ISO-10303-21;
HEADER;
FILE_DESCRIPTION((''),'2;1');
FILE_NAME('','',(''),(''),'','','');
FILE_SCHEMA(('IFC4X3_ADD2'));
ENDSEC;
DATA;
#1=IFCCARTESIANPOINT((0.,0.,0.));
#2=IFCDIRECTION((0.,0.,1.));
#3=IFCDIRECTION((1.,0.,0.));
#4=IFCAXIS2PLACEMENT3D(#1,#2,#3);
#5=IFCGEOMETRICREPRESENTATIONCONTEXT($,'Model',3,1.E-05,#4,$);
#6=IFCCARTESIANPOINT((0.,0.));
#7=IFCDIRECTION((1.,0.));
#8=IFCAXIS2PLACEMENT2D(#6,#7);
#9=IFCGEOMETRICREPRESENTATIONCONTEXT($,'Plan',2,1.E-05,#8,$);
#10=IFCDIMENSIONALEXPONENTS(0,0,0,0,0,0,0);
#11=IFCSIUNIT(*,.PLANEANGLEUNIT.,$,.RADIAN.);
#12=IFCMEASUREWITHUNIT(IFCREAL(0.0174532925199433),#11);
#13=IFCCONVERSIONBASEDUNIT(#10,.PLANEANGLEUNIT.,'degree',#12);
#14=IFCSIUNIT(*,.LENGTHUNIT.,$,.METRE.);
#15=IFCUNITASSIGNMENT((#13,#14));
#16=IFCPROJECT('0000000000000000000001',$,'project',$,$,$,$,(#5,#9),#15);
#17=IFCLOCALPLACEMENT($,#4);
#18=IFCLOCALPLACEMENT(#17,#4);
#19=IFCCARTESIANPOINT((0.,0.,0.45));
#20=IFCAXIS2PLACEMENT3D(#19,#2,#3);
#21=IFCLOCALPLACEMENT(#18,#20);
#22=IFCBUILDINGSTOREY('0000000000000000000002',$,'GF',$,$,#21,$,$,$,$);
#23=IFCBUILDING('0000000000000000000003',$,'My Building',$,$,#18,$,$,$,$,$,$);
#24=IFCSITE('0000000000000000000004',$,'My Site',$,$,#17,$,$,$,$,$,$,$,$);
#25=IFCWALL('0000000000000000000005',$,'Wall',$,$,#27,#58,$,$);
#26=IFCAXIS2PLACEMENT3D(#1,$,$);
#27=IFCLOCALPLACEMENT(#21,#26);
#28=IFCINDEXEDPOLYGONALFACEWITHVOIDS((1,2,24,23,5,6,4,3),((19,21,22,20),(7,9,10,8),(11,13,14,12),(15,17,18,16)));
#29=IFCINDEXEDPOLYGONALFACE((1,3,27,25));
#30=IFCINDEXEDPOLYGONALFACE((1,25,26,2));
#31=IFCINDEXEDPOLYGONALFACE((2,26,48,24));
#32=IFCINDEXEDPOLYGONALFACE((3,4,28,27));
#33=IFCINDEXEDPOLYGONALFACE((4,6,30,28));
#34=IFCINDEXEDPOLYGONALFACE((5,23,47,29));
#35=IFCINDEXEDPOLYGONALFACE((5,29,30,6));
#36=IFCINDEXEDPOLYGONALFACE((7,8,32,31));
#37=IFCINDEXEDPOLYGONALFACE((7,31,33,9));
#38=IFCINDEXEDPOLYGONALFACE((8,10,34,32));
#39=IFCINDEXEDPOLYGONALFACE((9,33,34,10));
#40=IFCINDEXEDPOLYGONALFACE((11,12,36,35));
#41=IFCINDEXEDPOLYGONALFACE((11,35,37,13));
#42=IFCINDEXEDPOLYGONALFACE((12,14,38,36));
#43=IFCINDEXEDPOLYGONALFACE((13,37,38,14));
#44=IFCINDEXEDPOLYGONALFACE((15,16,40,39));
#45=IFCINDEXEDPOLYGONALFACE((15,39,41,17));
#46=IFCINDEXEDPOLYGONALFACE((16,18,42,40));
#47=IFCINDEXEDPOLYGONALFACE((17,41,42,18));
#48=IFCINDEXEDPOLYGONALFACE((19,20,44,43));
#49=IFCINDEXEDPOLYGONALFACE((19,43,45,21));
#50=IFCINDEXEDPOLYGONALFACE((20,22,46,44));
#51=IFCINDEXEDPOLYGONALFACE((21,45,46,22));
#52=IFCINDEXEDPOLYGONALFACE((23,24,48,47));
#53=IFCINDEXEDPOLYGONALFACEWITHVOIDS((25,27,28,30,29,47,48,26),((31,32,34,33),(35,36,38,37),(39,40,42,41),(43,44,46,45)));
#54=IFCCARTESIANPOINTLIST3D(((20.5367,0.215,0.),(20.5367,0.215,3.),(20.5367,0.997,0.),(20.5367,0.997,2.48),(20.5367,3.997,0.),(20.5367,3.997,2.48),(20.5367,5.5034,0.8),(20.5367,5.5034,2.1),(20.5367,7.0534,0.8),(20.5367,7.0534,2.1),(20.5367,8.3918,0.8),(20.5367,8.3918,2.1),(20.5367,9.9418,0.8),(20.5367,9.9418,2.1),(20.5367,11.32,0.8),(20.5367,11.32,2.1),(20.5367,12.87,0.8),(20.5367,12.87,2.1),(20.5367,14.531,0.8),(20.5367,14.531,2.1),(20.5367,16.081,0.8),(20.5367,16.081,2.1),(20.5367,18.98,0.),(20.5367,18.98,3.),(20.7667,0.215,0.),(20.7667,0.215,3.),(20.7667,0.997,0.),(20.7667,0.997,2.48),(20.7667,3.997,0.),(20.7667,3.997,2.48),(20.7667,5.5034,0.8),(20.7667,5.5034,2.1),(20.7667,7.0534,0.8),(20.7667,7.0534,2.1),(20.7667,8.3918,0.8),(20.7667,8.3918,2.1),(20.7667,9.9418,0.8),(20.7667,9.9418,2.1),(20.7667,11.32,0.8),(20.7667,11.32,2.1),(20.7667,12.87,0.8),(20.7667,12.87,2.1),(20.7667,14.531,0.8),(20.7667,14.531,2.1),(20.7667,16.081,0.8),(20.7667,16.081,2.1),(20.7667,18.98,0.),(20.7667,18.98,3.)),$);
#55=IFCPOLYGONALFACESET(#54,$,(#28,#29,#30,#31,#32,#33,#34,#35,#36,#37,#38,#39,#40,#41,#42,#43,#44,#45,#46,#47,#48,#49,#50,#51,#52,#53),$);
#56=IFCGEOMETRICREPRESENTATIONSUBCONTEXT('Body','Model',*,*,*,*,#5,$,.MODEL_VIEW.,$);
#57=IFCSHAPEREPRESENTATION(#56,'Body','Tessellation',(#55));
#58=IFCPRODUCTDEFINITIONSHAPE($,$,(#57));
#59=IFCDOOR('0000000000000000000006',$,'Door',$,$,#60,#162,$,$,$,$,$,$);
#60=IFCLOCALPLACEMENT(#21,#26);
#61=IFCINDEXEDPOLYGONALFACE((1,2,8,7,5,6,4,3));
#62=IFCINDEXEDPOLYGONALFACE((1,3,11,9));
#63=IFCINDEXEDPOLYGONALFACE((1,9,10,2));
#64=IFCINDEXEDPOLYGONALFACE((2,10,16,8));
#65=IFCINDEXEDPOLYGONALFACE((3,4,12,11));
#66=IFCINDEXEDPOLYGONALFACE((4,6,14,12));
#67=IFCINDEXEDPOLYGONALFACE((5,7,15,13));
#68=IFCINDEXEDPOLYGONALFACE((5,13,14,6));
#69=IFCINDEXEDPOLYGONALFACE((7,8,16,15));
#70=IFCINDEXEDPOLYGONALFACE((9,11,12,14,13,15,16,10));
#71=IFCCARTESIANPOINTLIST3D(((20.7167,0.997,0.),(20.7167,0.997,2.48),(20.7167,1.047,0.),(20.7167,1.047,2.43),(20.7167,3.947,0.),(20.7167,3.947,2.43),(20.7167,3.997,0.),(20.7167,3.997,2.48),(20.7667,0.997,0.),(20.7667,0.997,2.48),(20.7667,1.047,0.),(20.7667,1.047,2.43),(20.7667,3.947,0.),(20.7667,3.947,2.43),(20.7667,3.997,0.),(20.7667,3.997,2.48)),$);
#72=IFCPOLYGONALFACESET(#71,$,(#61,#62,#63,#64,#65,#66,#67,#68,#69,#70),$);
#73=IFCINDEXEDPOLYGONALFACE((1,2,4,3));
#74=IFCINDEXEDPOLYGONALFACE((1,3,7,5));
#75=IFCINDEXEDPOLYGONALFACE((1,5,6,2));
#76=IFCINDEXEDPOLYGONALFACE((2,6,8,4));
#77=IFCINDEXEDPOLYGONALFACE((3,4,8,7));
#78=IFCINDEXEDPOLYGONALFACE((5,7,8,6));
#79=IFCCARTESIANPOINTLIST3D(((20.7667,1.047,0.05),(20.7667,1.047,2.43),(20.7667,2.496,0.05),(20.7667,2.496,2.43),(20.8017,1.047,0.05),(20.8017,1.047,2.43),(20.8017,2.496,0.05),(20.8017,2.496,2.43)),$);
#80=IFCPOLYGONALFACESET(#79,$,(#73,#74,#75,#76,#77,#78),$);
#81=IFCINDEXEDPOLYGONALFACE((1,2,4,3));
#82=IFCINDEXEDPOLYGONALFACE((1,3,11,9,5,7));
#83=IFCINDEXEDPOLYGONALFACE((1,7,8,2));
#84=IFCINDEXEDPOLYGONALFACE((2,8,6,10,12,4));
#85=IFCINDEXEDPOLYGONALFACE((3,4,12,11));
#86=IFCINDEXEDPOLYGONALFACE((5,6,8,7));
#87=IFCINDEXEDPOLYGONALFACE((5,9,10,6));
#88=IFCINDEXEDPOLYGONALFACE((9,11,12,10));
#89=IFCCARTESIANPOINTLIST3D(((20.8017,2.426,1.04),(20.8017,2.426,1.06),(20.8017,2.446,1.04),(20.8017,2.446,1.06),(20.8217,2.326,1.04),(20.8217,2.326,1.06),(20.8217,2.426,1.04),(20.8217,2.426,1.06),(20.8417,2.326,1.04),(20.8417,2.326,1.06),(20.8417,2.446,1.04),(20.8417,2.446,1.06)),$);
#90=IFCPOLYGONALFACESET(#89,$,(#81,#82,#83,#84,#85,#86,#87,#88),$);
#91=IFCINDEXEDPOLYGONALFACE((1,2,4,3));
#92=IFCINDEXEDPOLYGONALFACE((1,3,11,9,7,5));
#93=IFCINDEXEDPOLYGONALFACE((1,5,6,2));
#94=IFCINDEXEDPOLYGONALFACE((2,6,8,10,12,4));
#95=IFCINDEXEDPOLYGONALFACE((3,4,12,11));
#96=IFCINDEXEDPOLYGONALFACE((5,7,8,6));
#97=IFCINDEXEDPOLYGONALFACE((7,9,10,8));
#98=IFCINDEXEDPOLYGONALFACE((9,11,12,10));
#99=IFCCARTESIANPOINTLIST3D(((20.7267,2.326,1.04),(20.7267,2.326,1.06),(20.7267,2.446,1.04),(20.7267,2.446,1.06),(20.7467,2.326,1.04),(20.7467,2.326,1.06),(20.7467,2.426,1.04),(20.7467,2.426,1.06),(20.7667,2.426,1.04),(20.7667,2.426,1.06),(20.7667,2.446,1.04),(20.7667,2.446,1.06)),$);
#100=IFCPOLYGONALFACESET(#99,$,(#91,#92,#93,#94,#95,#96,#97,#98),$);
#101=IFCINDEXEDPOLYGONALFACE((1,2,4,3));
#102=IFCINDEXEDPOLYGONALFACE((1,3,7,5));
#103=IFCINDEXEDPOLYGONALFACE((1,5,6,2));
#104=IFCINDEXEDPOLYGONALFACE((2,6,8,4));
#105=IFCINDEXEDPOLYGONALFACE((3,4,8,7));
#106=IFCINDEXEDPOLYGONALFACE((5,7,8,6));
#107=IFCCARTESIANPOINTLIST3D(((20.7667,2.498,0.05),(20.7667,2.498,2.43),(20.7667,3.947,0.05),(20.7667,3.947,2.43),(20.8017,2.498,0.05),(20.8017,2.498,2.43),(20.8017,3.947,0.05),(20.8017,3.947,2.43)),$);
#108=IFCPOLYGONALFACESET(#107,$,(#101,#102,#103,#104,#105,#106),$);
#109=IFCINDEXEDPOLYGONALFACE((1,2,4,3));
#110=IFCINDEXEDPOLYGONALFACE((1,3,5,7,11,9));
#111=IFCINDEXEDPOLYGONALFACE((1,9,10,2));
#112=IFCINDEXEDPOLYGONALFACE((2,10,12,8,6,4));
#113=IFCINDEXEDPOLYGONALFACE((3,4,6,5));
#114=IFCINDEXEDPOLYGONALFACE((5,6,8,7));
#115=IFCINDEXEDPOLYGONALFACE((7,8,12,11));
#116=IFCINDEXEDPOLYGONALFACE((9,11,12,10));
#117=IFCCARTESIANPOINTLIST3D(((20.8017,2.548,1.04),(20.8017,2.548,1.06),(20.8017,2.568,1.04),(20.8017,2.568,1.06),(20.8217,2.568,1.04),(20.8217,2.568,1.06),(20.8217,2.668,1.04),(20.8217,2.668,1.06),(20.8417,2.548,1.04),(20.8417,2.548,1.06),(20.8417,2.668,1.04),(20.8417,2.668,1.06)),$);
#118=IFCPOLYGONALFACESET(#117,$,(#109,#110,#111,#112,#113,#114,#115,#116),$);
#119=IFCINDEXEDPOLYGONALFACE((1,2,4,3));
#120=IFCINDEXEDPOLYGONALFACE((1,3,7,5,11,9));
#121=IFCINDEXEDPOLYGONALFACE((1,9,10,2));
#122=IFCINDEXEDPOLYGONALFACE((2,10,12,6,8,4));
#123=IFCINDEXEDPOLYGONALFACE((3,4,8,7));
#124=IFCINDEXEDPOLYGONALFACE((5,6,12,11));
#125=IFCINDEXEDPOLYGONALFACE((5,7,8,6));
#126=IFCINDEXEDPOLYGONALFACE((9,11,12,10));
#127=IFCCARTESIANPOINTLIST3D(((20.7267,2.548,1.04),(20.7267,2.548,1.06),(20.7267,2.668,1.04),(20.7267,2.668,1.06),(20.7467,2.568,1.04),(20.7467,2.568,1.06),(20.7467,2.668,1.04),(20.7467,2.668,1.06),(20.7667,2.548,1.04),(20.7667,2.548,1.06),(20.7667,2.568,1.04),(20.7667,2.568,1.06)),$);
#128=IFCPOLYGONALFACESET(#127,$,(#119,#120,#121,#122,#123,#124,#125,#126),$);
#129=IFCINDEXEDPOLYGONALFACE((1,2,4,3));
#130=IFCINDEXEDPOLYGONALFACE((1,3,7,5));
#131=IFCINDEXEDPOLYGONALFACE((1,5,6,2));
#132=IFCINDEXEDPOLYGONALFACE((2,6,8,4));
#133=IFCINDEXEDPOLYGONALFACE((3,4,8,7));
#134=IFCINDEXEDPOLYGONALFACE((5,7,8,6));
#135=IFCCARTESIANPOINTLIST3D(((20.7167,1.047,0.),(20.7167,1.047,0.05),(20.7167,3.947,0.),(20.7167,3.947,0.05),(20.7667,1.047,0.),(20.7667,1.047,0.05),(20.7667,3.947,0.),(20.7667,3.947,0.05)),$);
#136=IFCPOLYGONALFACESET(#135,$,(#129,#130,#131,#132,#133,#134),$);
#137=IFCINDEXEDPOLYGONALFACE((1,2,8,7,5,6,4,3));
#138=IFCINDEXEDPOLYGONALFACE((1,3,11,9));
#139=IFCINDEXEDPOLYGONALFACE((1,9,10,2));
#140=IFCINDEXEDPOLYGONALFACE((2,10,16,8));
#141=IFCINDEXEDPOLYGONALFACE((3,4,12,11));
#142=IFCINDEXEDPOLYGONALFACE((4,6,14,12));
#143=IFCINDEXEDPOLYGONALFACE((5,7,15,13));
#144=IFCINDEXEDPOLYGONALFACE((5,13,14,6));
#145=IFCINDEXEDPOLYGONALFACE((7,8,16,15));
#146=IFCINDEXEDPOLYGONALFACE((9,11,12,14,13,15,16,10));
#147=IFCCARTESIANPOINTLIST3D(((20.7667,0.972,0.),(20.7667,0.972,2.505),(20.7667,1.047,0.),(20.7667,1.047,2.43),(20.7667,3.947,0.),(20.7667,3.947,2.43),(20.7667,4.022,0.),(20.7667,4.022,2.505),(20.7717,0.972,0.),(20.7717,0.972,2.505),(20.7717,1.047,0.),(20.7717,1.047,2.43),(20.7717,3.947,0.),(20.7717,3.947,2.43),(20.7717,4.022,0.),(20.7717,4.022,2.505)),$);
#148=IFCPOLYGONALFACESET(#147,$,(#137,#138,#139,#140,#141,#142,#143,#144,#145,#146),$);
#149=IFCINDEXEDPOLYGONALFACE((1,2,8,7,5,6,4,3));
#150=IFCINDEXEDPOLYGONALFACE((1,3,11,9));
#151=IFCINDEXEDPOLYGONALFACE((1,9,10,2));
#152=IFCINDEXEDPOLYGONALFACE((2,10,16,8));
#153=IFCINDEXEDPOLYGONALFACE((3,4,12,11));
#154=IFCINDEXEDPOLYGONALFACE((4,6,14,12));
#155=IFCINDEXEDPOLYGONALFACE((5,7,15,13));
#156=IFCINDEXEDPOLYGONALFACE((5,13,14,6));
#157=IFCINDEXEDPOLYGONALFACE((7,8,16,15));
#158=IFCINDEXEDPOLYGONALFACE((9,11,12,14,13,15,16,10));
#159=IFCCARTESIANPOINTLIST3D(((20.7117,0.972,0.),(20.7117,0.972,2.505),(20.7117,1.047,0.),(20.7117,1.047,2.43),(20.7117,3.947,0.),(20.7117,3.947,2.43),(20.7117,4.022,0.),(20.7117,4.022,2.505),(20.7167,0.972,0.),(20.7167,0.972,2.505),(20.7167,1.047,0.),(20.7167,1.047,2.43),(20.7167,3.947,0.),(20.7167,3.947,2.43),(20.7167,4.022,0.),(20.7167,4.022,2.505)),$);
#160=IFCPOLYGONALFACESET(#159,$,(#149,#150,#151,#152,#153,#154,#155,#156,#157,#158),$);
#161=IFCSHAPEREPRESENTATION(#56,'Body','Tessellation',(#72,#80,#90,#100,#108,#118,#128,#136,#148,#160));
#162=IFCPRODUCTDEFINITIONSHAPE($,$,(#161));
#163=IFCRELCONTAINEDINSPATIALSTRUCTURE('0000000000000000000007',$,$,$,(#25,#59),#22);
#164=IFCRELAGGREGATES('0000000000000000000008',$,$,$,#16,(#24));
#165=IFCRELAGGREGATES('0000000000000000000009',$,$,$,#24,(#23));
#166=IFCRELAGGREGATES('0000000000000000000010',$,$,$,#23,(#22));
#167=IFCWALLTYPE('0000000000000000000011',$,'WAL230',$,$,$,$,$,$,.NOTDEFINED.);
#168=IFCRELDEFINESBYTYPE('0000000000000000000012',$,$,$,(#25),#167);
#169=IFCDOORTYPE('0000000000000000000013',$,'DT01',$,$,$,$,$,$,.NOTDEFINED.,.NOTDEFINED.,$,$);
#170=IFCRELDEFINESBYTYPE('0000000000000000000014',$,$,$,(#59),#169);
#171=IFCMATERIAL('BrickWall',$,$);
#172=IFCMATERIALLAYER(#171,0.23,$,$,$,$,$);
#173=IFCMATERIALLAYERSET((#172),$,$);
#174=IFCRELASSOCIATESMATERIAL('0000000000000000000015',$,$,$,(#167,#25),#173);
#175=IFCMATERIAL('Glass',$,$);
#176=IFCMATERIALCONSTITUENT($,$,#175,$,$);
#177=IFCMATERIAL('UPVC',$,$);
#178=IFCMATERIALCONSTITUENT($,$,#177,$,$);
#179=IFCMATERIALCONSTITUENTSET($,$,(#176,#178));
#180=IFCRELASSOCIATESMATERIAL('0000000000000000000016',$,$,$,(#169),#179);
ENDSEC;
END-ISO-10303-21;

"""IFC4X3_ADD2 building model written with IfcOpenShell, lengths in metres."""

from ifc_helpers import new_model, entity, si_unit, converted_unit, frame, origin_with_axes, origin_2d_with_axis, place, context, subcontext, project, spatial, line, indexed_curve, outline, extrude, shape, source, transform, mapped, material, layer, layer_set, layer_usage, constituent, constituent_set, type_object, type_shapes, element, fill, save


model = new_model("IFC4X3_ADD2")

# Units and contexts
model_context = context("Model", 3, precision=1e-05, world=origin_with_axes())
plan_context = context("Plan", 2, precision=1e-05, world=origin_2d_with_axis())
body_context_1 = subcontext(model_context, "Body", "Model", "MODEL_VIEW")
body_context_2 = subcontext(plan_context, "Body", "Plan", "PLAN_VIEW")
ifc_project = project(units=[converted_unit("PLANEANGLEUNIT", "degree", entity("IfcReal", 0.0174532925199433), si_unit("PLANEANGLEUNIT", "RADIAN"), dimensions=[0, 0, 0, 0, 0, 0, 0]), si_unit("LENGTHUNIT", "METRE")], contexts=[model_context, plan_context])

# Site, building, storey
site_placement = place(None, origin_with_axes())
site = spatial("IfcSite", under=ifc_project, at=site_placement, Name="My Site")
building_placement = place(site_placement, origin_with_axes())
building = spatial("IfcBuilding", under=site, at=building_placement, Name="My Building")
storey_placement = place(building_placement, frame((0.0, 0.0, 0.45), z_axis=(0.0, 0.0, 1.0), x_axis=(1.0, 0.0, 0.0)))
storey = spatial("IfcBuildingStorey", under=building, at=storey_placement, Name="GF")

# Shared definitions
ifc_material_1 = material(Name="BrickWall")
ifc_layer_1 = layer(ifc_material_1, 0.23)
ifc_layer_set_1 = layer_set([ifc_layer_1])
wall_type_1 = type_object("IfcWallType", Name="WAL230", PredefinedType="NOTDEFINED", material=ifc_layer_set_1)
shared_shape_1 = source(origin_with_axes(), body_context_1, "Body", "SweptSolid", [
    extrude(outline(indexed_curve([(0.0, 0.0), (3.0, 0.0), (3.0, 2.48), (0.0, 2.48)], segments=[line(1, 2, 3, 4, 1)])), frame((0.0, -0.6, 0.0), z_axis=(0.0, -1.0, 0.0), x_axis=(1.0, 0.0, 0.0)), (0.0, 0.0, -1.0), 1.2),
])
ifc_material_2 = material(Name="Glass")
ifc_constituent_1 = constituent(ifc_material_2)
ifc_material_3 = material(Name="UPVC")
ifc_constituent_2 = constituent(ifc_material_3)
ifc_constituent_set = constituent_set(constituents=[ifc_constituent_1, ifc_constituent_2])
door_type_1 = type_object("IfcDoorType", Name="DT01", OperationType="NOTDEFINED", PredefinedType="NOTDEFINED", material=ifc_constituent_set)
shared_shape_2 = source(origin_with_axes(), body_context_1, "Body", "SweptSolid", [
    extrude(outline(indexed_curve([(3.0, 0.0), (3.0, 2.48), (0.0, 2.48), (0.0, 0.0), (0.05, 0.0), (0.05, 2.43), (2.95, 2.43), (2.95, 0.0)], segments=[line(5, 4), line(4, 3), line(3, 2), line(2, 1), line(1, 8), line(8, 7), line(7, 6), line(6, 5)], self_intersect=False)), frame((0.0, 0.0, 0.0), z_axis=(0.0, -1.0, 0.0), x_axis=(1.0, 0.0, 0.0)), (0.0, 0.0, -1.0), 0.05),
    extrude(outline(indexed_curve([(0.0, 0.0), (1.449, 0.0), (1.449, 0.035), (0.0, 0.035)], segments=[line(1, 2, 3, 4, 1)])), frame((0.05, -0.035, 0.05), z_axis=(0.0, 0.0, 1.0), x_axis=(1.0, 0.0, 0.0)), (0.0, 0.0, 1.0), 2.38),
    extrude(outline(indexed_curve([(0.0, 0.0), (0.0, -0.04), (-0.12, -0.04), (-0.12, -0.02), (-0.02, -0.02), (-0.02, 0.0)], segments=[line(1, 2, 3, 4, 5, 6, 1)])), frame((1.449, -0.035, 1.04), z_axis=(0.0, 0.0, 1.0), x_axis=(1.0, 0.0, 0.0)), (0.0, 0.0, 1.0), 0.02),
    extrude(outline(indexed_curve([(0.0, 0.0), (0.0, 0.04), (-0.12, 0.04), (-0.12, 0.02), (-0.02, 0.02), (-0.02, 0.0)], segments=[line(1, 2, 3, 4, 5, 6, 1)])), frame((1.449, 0.0, 1.04), z_axis=(0.0, 0.0, 1.0), x_axis=(1.0, 0.0, 0.0)), (0.0, 0.0, 1.0), 0.02),
    extrude(outline(indexed_curve([(0.0, 0.0), (-1.449, 0.0), (-1.449, 0.035), (0.0, 0.035)], segments=[line(1, 2, 3, 4, 1)])), frame((2.95, -0.035, 0.05), z_axis=(0.0, 0.0, 1.0), x_axis=(1.0, 0.0, 0.0)), (0.0, 0.0, 1.0), 2.38),
    extrude(outline(indexed_curve([(0.0, 0.0), (0.0, -0.04), (0.12, -0.04), (0.12, -0.02), (0.02, -0.02), (0.02, 0.0)], segments=[line(1, 2, 3, 4, 5, 6, 1)])), frame((1.551, -0.035, 1.04), z_axis=(0.0, 0.0, 1.0), x_axis=(1.0, 0.0, 0.0)), (0.0, 0.0, 1.0), 0.02),
    extrude(outline(indexed_curve([(0.0, 0.0), (0.0, 0.04), (0.12, 0.04), (0.12, 0.02), (0.02, 0.02), (0.02, 0.0)], segments=[line(1, 2, 3, 4, 5, 6, 1)])), frame((1.551, 0.0, 1.04), z_axis=(0.0, 0.0, 1.0), x_axis=(1.0, 0.0, 0.0)), (0.0, 0.0, 1.0), 0.02),
    extrude(outline(indexed_curve([(0.0, 0.0), (2.9, 0.0), (2.9, 0.05), (0.0, 0.05)], segments=[line(1, 2, 3, 4, 1)])), frame((0.05, 0.0, 0.0), z_axis=(0.0, 0.0, 1.0), x_axis=(1.0, 0.0, 0.0)), (0.0, 0.0, 1.0), 0.05),
    extrude(outline(indexed_curve([(0.0, 0.0), (0.0, 2.505), (3.05, 2.505), (3.05, 0.0), (2.975, 0.0), (2.975, 2.43), (0.075, 2.43), (0.075, 0.0)], segments=[line(1, 2, 3, 4, 5, 6, 7, 8, 1)])), frame((-0.025, -0.005, 0.0), z_axis=(0.0, -1.0, 0.0), x_axis=(1.0, 0.0, 0.0)), (0.0, 0.0, -1.0), 0.005),
    extrude(outline(indexed_curve([(0.0, 0.0), (0.0, 2.505), (3.05, 2.505), (3.05, 0.0), (2.975, 0.0), (2.975, 2.43), (0.075, 2.43), (0.075, 0.0)], segments=[line(1, 2, 3, 4, 5, 6, 7, 8, 1)])), frame((-0.025, 0.05, 0.0), z_axis=(0.0, -1.0, 0.0), x_axis=(1.0, 0.0, 0.0)), (0.0, 0.0, -1.0), 0.005),
])
shared_shape_3 = source(origin_with_axes(), body_context_2, "Body", "Curve2D", [
    entity("IfcIndexedPolyCurve", entity("IfcCartesianPointList2D", [[0.0, 0.0], [0.05, 0.0], [0.05, 0.05], [0.0, 0.05]]), [entity("IfcLineIndex", [1, 2, 3, 4, 1])]),
    entity("IfcIndexedPolyCurve", entity("IfcCartesianPointList2D", [[3.0, 0.0], [2.95, 0.0], [2.95, 0.05], [3.0, 0.05]]), [entity("IfcLineIndex", [1, 2, 3, 4, 1])]),
    entity("IfcIndexedPolyCurve", entity("IfcCartesianPointList2D", [[-0.675, -0.035], [0.775, -0.035], [0.775, 0.0], [-0.675, 0.0]]), [entity("IfcLineIndex", [1, 2, 3, 4, 1])]),
    entity("IfcIndexedPolyCurve", entity("IfcCartesianPointList2D", [[3.675, -0.035], [2.225, -0.035], [2.225, 0.0], [3.675, 0.0]]), [entity("IfcLineIndex", [1, 2, 3, 4, 1])]),
])
type_shapes(door_type_1, [shared_shape_2, shared_shape_3])

# Wall, openings, door
ifc_layer_usage_1 = layer_usage(ifc_layer_set_1, "AXIS2", "POSITIVE", 0.0)
wall_1_placement = place(storey_placement, frame((20.7667, 0.215, 0.0), z_axis=(0.0, 0.0, 1.0), x_axis=(0.0, 1.0, 0.0)))
wall_1 = element("IfcWall", 1, at=wall_1_placement, inside=storey, type_object=wall_type_1, material=ifc_layer_usage_1, Name="Wall", context=body_context_1, shape_type="SweptSolid", body=[
    extrude(outline(indexed_curve([(0.0, 0.0), (0.0, 0.23), (18.765, 0.23), (18.765, 0.0), (0.0, 0.0)], self_intersect=False)), origin_with_axes(), (0.0, 0.0, 1.0), 3.0),
])
opening_1_placement = place(wall_1_placement, frame((0.782, 0.03, 0.0), z_axis=(0.0, 0.0, 1.0), x_axis=(1.0, 0.0, 0.0)))
opening_1 = element("IfcOpeningElement", 2, at=opening_1_placement, cuts=wall_1, PredefinedType="OPENING", context=body_context_1, shape_type="MappedRepresentation", body=[
    mapped(shared_shape_1, transform((0.0, 0.0, 0.0), x_axis=(1.0, 0.0, 0.0), y_axis=(0.0, 1.0, 0.0), z_axis=(0.0, 0.0, 1.0), scale=1.0)),
])
shared_shape_4 = source(origin_with_axes(), body_context_1, "Body", "SweptSolid", [
    extrude(outline(indexed_curve([(0.0, 0.0), (1.55, 0.0), (1.55, 1.3), (0.0, 1.3)], segments=[line(1, 2, 3, 4, 1)])), frame((-0.775, -0.6, 0.0), z_axis=(0.0, -1.0, 0.0), x_axis=(1.0, 0.0, 0.0)), (0.0, 0.0, -1.0), 1.2),
])
opening_2_placement = place(wall_1_placement, frame((6.0634, 0.0, 0.8), z_axis=(0.0, 0.0, 1.0), x_axis=(1.0, 0.0, 0.0)))
element("IfcOpeningElement", 3, at=opening_2_placement, cuts=wall_1, PredefinedType="OPENING", context=body_context_1, shape_type="MappedRepresentation", body=[
    mapped(shared_shape_4, transform((0.0, 0.0, 0.0), x_axis=(1.0, 0.0, 0.0), y_axis=(0.0, 1.0, 0.0), z_axis=(0.0, 0.0, 1.0), scale=1.0)),
])
opening_3_placement = place(wall_1_placement, frame((8.9518, 0.0, 0.8), z_axis=(0.0, 0.0, 1.0), x_axis=(1.0, 0.0, 0.0)))
element("IfcOpeningElement", 4, at=opening_3_placement, cuts=wall_1, PredefinedType="OPENING", context=body_context_1, shape_type="MappedRepresentation", body=[
    mapped(shared_shape_4, transform((0.0, 0.0, 0.0), x_axis=(1.0, 0.0, 0.0), y_axis=(0.0, 1.0, 0.0), z_axis=(0.0, 0.0, 1.0), scale=1.0)),
])
opening_4_placement = place(wall_1_placement, frame((11.88, 0.0, 0.8), z_axis=(0.0, 0.0, 1.0), x_axis=(1.0, 0.0, 0.0)))
element("IfcOpeningElement", 5, at=opening_4_placement, cuts=wall_1, PredefinedType="OPENING", context=body_context_1, shape_type="MappedRepresentation", body=[
    mapped(shared_shape_4, transform((0.0, 0.0, 0.0), x_axis=(1.0, 0.0, 0.0), y_axis=(0.0, 1.0, 0.0), z_axis=(0.0, 0.0, 1.0), scale=1.0)),
])
opening_5_placement = place(wall_1_placement, frame((15.091, 0.0, 0.8), z_axis=(0.0, 0.0, 1.0), x_axis=(1.0, 0.0, 0.0)))
element("IfcOpeningElement", 6, at=opening_5_placement, cuts=wall_1, PredefinedType="OPENING", context=body_context_1, shape_type="MappedRepresentation", body=[
    mapped(shared_shape_4, transform((0.0, 0.0, 0.0), x_axis=(1.0, 0.0, 0.0), y_axis=(0.0, 1.0, 0.0), z_axis=(0.0, 0.0, 1.0), scale=1.0)),
])
door_1_placement = place(opening_1_placement, frame((0.0, -0.03, 0.0), z_axis=(0.0, 0.0, 1.0), x_axis=(1.0, 0.0, 0.0)))
door_1 = element("IfcDoor", 7, at=door_1_placement, inside=storey, type_object=door_type_1, Name="Door", shapes=[
    shape(body_context_1, "Body", "MappedRepresentation", [mapped(shared_shape_2, transform((0.0, 0.0, 0.0), x_axis=(1.0, 0.0, 0.0), y_axis=(0.0, 1.0, 0.0), z_axis=(0.0, 0.0, 1.0), scale=1.0))]),
    shape(body_context_2, "Body", "MappedRepresentation", [mapped(shared_shape_3, transform((0.0, 0.0, 0.0), x_axis=(1.0, 0.0, 0.0), y_axis=(0.0, 1.0, 0.0), z_axis=(0.0, 0.0, 1.0), scale=1.0))]),
])
fill(opening_1, door_1)

save(model, "model.ifc")
